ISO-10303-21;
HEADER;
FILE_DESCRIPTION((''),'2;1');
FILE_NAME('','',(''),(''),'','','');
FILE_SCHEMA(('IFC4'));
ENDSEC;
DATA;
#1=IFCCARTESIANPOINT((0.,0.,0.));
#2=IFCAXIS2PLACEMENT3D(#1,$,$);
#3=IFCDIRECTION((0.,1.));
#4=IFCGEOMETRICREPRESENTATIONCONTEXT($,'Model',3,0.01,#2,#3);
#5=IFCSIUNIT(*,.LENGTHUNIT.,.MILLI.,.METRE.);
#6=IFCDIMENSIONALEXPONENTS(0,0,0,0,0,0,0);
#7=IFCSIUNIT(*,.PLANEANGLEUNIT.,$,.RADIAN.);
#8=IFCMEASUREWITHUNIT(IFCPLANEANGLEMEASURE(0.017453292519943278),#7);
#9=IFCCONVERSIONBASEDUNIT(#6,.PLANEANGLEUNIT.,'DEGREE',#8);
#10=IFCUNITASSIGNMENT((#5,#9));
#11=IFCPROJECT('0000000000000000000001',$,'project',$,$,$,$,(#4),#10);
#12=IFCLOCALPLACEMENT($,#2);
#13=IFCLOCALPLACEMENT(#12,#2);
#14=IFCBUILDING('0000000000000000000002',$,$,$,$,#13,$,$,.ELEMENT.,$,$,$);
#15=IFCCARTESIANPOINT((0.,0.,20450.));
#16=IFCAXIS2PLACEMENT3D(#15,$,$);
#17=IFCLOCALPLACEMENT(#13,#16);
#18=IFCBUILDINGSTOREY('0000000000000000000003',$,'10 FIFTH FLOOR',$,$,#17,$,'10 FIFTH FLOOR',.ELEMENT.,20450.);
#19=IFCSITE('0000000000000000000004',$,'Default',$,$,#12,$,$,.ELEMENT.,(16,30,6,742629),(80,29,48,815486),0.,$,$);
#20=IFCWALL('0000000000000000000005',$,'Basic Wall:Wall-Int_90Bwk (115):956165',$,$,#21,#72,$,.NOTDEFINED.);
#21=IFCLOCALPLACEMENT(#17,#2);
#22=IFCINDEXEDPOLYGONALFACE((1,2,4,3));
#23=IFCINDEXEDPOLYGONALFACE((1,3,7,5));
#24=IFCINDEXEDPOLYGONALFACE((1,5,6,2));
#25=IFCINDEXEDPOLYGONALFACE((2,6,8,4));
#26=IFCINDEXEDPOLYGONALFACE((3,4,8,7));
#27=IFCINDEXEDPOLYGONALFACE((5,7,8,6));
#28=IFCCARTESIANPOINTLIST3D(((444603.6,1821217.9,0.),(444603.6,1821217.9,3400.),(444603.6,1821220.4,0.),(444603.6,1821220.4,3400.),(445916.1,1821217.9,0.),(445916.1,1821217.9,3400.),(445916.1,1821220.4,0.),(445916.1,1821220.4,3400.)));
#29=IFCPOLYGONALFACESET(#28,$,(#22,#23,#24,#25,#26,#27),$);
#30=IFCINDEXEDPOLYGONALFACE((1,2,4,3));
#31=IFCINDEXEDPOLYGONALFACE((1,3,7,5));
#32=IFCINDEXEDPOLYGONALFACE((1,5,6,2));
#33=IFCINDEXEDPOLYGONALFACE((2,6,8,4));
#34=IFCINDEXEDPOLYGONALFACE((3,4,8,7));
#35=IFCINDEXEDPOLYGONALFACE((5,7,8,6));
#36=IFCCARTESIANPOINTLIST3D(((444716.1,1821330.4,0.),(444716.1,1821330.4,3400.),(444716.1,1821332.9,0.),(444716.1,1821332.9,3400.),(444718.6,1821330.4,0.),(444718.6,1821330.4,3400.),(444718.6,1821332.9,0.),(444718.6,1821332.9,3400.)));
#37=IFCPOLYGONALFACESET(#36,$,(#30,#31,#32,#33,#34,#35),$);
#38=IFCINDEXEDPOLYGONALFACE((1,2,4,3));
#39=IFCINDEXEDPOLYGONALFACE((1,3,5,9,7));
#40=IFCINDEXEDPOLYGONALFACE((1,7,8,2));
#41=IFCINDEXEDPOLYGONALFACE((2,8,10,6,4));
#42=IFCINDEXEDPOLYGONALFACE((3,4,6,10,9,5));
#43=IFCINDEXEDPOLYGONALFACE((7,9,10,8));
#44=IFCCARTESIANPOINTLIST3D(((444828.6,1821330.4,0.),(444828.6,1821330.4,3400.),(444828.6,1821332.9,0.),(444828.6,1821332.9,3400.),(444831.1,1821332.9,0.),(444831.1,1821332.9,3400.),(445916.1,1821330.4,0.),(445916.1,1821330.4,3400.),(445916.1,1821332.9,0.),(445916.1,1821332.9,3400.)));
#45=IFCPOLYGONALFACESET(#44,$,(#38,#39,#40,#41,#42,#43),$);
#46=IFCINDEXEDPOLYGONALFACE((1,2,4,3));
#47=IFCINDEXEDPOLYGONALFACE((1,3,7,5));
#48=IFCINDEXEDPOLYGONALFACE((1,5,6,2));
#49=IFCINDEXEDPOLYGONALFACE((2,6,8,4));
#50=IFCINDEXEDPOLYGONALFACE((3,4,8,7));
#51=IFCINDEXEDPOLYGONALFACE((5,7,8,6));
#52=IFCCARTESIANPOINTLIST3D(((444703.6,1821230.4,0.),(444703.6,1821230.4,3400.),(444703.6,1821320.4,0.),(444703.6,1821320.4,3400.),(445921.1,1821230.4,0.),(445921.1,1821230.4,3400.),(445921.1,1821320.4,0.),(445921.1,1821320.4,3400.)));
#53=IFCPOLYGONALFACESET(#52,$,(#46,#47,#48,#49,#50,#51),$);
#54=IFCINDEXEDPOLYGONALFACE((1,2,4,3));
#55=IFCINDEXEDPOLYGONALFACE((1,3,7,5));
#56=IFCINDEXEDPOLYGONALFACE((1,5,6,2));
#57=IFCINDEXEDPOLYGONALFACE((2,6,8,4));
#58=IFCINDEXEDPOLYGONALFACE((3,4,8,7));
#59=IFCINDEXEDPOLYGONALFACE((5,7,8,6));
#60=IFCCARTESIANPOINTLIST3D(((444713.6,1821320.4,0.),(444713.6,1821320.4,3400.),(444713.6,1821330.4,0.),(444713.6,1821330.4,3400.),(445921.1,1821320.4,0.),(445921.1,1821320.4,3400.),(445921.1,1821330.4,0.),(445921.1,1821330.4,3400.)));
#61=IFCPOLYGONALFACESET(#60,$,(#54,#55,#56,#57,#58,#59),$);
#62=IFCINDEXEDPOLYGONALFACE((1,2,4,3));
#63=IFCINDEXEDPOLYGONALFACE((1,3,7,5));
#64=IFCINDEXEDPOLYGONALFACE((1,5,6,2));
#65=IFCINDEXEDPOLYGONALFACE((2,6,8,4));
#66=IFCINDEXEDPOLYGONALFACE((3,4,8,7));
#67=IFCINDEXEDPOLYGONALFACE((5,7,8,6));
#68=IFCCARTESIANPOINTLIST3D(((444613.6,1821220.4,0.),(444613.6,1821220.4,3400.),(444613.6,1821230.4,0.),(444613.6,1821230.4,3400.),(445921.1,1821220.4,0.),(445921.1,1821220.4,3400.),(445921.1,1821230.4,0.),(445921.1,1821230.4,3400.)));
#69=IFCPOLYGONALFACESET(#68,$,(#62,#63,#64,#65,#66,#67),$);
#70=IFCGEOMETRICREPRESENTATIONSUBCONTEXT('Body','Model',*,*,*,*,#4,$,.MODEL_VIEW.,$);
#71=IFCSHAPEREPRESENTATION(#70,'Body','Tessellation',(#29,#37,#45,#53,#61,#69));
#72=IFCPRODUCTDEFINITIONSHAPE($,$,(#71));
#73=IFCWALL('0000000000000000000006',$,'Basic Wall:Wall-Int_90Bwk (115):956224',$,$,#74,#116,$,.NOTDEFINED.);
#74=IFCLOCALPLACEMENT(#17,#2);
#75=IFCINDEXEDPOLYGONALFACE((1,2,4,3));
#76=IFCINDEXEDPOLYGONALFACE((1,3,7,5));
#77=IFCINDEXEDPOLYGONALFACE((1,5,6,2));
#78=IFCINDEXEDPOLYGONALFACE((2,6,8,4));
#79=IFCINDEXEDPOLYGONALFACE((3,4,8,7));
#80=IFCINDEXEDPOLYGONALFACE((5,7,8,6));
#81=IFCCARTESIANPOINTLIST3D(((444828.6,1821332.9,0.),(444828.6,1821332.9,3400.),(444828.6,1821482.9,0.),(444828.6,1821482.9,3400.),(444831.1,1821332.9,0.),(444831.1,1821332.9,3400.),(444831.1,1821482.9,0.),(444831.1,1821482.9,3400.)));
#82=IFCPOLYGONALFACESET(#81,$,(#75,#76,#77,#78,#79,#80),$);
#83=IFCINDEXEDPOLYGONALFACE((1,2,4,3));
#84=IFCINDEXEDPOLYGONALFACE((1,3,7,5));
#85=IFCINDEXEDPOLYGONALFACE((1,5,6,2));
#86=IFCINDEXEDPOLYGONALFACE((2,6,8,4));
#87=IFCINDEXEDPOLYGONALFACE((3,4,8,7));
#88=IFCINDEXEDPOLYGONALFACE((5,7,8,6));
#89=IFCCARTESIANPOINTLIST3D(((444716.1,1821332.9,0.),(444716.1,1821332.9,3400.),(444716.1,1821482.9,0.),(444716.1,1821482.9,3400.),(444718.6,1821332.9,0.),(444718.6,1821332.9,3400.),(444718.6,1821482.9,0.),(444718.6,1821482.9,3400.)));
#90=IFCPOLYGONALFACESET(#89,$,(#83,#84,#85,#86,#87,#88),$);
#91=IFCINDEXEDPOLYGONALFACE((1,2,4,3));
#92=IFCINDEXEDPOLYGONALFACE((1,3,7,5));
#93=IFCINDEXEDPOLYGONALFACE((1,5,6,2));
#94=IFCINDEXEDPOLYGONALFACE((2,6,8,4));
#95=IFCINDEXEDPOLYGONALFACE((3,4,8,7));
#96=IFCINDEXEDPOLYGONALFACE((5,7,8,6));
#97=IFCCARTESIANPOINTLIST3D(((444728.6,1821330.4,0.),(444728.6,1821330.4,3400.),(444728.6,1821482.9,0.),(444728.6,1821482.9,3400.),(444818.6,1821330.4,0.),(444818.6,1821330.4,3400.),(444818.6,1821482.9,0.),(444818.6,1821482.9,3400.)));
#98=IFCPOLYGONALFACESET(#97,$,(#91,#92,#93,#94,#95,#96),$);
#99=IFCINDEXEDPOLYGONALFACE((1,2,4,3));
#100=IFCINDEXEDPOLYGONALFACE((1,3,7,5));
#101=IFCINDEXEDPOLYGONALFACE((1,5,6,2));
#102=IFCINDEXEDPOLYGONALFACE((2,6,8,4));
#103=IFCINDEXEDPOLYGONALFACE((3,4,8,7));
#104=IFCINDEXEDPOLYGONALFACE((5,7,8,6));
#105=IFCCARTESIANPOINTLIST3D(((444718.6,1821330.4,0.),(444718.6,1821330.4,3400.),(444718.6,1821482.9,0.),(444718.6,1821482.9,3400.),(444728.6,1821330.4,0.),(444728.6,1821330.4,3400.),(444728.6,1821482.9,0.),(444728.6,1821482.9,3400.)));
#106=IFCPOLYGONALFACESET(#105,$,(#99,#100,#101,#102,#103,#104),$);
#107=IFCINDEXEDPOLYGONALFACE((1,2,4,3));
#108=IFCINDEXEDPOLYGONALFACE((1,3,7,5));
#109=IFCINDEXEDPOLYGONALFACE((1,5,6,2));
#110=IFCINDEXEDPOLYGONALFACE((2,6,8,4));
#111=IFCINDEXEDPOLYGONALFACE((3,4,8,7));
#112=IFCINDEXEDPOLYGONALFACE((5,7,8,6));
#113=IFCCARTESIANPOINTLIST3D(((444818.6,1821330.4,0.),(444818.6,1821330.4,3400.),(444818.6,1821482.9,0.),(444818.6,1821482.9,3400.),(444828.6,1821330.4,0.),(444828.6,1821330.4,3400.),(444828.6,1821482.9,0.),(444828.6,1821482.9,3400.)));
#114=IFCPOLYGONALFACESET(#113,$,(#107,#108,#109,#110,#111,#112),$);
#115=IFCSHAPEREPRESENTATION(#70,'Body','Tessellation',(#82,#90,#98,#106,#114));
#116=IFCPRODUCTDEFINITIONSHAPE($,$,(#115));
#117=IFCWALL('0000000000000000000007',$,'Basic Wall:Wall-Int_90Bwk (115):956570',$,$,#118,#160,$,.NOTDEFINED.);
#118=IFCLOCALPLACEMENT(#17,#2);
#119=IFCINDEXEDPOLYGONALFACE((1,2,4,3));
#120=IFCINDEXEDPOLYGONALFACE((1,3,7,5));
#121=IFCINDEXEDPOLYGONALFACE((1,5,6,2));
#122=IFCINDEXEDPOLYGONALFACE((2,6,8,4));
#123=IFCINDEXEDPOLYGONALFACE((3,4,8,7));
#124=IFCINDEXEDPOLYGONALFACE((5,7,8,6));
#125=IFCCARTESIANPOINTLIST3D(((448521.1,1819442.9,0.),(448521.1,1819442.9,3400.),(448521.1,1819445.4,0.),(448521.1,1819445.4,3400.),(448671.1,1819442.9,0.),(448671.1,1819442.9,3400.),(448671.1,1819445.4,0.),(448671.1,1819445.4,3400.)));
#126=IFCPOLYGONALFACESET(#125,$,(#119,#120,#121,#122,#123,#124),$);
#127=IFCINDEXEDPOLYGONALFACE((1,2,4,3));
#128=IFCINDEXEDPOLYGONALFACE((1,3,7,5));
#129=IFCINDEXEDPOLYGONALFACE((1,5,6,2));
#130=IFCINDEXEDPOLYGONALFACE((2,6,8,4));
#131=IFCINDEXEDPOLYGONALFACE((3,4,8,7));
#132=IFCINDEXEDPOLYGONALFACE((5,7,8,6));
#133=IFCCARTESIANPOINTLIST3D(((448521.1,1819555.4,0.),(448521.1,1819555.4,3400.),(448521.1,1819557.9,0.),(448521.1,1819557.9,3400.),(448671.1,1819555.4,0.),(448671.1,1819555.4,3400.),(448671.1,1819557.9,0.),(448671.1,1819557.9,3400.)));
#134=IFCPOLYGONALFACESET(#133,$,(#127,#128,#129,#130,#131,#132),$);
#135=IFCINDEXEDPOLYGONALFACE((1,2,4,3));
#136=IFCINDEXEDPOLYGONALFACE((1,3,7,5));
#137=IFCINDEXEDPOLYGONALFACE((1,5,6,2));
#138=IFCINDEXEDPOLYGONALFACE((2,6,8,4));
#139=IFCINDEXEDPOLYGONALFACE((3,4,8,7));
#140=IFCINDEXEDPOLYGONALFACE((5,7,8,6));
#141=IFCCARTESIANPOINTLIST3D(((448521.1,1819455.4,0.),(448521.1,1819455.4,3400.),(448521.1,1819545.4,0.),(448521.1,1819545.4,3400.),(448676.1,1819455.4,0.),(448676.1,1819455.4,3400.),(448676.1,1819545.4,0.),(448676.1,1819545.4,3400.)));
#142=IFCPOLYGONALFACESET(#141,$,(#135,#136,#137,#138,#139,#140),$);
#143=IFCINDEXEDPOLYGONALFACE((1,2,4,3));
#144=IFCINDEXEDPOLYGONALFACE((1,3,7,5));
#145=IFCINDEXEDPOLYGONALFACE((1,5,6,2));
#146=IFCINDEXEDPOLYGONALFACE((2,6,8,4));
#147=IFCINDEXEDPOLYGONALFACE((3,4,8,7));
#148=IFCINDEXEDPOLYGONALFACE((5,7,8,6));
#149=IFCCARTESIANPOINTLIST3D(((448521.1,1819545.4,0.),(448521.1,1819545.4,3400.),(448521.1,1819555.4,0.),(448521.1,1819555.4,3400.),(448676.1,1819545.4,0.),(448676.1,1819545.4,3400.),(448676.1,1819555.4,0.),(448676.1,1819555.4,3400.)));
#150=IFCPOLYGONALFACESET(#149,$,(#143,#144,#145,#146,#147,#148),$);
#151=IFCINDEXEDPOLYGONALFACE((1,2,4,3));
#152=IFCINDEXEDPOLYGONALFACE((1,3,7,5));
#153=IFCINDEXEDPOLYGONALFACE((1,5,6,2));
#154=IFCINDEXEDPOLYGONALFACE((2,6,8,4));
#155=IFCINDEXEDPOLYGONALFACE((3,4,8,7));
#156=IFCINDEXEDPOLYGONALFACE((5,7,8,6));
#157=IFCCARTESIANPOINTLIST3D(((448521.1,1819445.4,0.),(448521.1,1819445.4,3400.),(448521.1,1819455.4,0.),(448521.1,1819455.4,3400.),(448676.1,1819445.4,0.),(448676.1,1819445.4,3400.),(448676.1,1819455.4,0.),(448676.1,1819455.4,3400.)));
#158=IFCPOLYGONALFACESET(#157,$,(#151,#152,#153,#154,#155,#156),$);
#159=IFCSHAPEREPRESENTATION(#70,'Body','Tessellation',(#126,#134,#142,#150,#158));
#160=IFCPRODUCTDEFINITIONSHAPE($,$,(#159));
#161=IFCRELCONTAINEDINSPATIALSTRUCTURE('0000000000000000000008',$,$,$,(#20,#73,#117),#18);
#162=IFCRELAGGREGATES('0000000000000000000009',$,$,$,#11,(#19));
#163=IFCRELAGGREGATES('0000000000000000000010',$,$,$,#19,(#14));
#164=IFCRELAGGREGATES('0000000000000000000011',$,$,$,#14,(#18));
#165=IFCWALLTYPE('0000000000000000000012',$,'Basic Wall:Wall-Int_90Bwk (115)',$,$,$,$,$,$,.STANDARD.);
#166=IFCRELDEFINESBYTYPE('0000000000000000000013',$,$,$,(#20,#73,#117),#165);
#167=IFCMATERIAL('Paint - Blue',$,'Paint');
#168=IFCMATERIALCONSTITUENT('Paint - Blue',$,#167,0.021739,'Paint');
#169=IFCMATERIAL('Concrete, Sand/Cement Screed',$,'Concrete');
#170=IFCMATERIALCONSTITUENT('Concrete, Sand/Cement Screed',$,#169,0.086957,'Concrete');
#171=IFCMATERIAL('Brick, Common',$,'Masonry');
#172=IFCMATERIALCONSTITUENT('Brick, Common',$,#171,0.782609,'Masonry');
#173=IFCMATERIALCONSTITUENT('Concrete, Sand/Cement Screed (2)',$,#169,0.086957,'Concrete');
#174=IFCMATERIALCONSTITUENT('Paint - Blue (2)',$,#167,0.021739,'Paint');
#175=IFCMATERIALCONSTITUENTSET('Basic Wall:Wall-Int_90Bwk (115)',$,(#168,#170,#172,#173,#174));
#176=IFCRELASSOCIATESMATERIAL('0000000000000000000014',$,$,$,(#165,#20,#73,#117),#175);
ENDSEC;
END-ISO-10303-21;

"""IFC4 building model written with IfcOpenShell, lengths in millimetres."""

from ifc_helpers import new_model, entity, si_unit, converted_unit, direction, frame, origin, place, context, subcontext, project, spatial, indexed_curve, outline, extrude, material, constituent, constituent_set, type_object, element, save


model = new_model("IFC4")

# Units and contexts
model_context = context("Model", 3, precision=0.01, world=origin(), true_north=direction((0.0, 1.0)))
body_context = subcontext(model_context, "Body", "Model", "MODEL_VIEW")
ifc_project = project(units=[si_unit("LENGTHUNIT", "METRE", prefix="MILLI"), converted_unit("PLANEANGLEUNIT", "DEGREE", entity("IfcPlaneAngleMeasure", 0.017453292519943278), si_unit("PLANEANGLEUNIT", "RADIAN"), dimensions=[0, 0, 0, 0, 0, 0, 0])], contexts=[model_context])

# Site, building, storey
site_placement = place(None, origin())
site = spatial("IfcSite", under=ifc_project, at=site_placement, Name="Default", CompositionType="ELEMENT", RefLatitude=(16, 30, 6, 742629), RefLongitude=(80, 29, 48, 815486), RefElevation=0.0)
building_placement = place(site_placement, origin())
building = spatial("IfcBuilding", under=site, at=building_placement, CompositionType="ELEMENT")
storey_placement = place(building_placement, frame((0.0, 0.0, 20450.0)))
storey = spatial("IfcBuildingStorey", under=building, at=storey_placement, Name="10 FIFTH FLOOR", LongName="10 FIFTH FLOOR", CompositionType="ELEMENT", Elevation=20450.0)

# Shared definitions
ifc_material_1 = material(Name="Paint - Blue", Category="Paint")
ifc_constituent_1 = constituent(ifc_material_1, Name="Paint - Blue", Category="Paint", fraction=0.021739)
ifc_material_2 = material(Name="Concrete, Sand/Cement Screed", Category="Concrete")
ifc_constituent_2 = constituent(ifc_material_2, Name="Concrete, Sand/Cement Screed", Category="Concrete", fraction=0.086957)
ifc_material_3 = material(Name="Brick, Common", Category="Masonry")
ifc_constituent_3 = constituent(ifc_material_3, Name="Brick, Common", Category="Masonry", fraction=0.782609)
ifc_constituent_4 = constituent(ifc_material_2, Name="Concrete, Sand/Cement Screed (2)", Category="Concrete", fraction=0.086957)
ifc_constituent_5 = constituent(ifc_material_1, Name="Paint - Blue (2)", Category="Paint", fraction=0.021739)
ifc_constituent_set_1 = constituent_set(constituents=[ifc_constituent_1, ifc_constituent_2, ifc_constituent_3, ifc_constituent_4, ifc_constituent_5], Name="Basic Wall:Wall-Int_90Bwk (115)")
wall_type_1 = type_object("IfcWallType", Name="Basic Wall:Wall-Int_90Bwk (115)", PredefinedType="STANDARD", material=ifc_constituent_set_1)

# Walls
wall_1_placement = place(storey_placement, frame((445916.1, 1821275.4, 0.0), z_axis=(0.0, 0.0, 1.0), x_axis=(-1.0, 0.0, 0.0)))
element("IfcWall", 1, at=wall_1_placement, inside=storey, type_object=wall_type_1, material=ifc_constituent_set_1, Name="Basic Wall:Wall-Int_90Bwk (115):956165", PredefinedType="NOTDEFINED", context=body_context, shape_type="SweptSolid", body=[
    extrude(outline(indexed_curve([(-1.3, -656.2), (1.3, -656.2), (1.3, 656.2), (-1.3, 656.2), (-1.3, -656.2)], self_intersect=False)), frame((656.2, 56.3, 0.0), z_axis=(0.0, 0.0, 1.0), x_axis=(0.0, -1.0, 0.0)), (0.0, 0.0, 1.0), 3400.0),
    extrude(outline(indexed_curve([(-1.3, -1.3), (1.3, -1.3), (1.3, 1.2), (-1.3, 1.2), (-1.3, -1.3)], self_intersect=False)), frame((1198.7, -56.3, 0.0), z_axis=(0.0, 0.0, 1.0), x_axis=(-1.0, 0.0, 0.0)), (0.0, 0.0, 1.0), 3400.0),
    extrude(outline(indexed_curve([(433.0, -1.0), (435.5, -1.0), (435.5, 1.5), (-652.0, 1.5), (-652.0, -1.0), (433.0, -1.0)], self_intersect=False)), frame((652.0, -56.5, 0.0)), (0.0, 0.0, 1.0), 3400.0),
    extrude(outline(indexed_curve([(-608.7, -45.0), (608.7, -45.0), (608.7, 45.0), (-608.7, 45.0), (-608.7, -45.0)], self_intersect=False)), frame((603.7, 0.0, 0.0)), (0.0, 0.0, 1.0), 3400.0),
    extrude(outline(indexed_curve([(-603.7, -5.0), (603.7, -5.0), (603.7, 5.0), (-603.7, 5.0), (-603.7, -5.0)], self_intersect=False)), frame((598.7, -50.0, 0.0)), (0.0, 0.0, 1.0), 3400.0),
    extrude(outline(indexed_curve([(-653.7, -5.0), (653.7, -5.0), (653.7, 5.0), (-653.7, 5.0), (-653.7, -5.0)], self_intersect=False)), frame((648.7, 50.0, 0.0)), (0.0, 0.0, 1.0), 3400.0),
])
wall_2_placement = place(storey_placement, frame((444773.6, 1821332.9, 0.0), z_axis=(0.0, 0.0, 1.0), x_axis=(0.0, 1.0, 0.0)))
element("IfcWall", 2, at=wall_2_placement, inside=storey, type_object=wall_type_1, material=ifc_constituent_set_1, Name="Basic Wall:Wall-Int_90Bwk (115):956224", PredefinedType="NOTDEFINED", context=body_context, shape_type="SweptSolid", body=[
    extrude(outline(indexed_curve([(-1.3, -75.0), (1.2, -75.0), (1.2, 75.0), (-1.3, 75.0), (-1.3, -75.0)], self_intersect=False)), frame((75.0, -56.2, 0.0), z_axis=(0.0, 0.0, 1.0), x_axis=(0.0, 1.0, 0.0)), (0.0, 0.0, 1.0), 3400.0),
    extrude(outline(indexed_curve([(-1.3, -75.0), (1.2, -75.0), (1.2, 75.0), (-1.3, 75.0), (-1.3, -75.0)], self_intersect=False)), frame((75.0, 56.2, 0.0), z_axis=(0.0, 0.0, 1.0), x_axis=(0.0, -1.0, 0.0)), (0.0, 0.0, 1.0), 3400.0),
    extrude(outline(indexed_curve([(-76.3, -45.0), (76.3, -45.0), (76.3, 45.0), (-76.3, 45.0), (-76.3, -45.0)], self_intersect=False)), frame((73.8, 0.0, 0.0)), (0.0, 0.0, 1.0), 3400.0),
    extrude(outline(indexed_curve([(-76.3, -5.0), (76.3, -5.0), (76.3, 5.0), (-76.3, 5.0), (-76.3, -5.0)], self_intersect=False)), frame((73.8, 50.0, 0.0)), (0.0, 0.0, 1.0), 3400.0),
    extrude(outline(indexed_curve([(-76.3, -5.0), (76.3, -5.0), (76.3, 5.0), (-76.3, 5.0), (-76.3, -5.0)], self_intersect=False)), frame((73.8, -50.0, 0.0)), (0.0, 0.0, 1.0), 3400.0),
])
wall_3_placement = place(storey_placement, frame((448671.1, 1819500.4, 0.0), z_axis=(0.0, 0.0, 1.0), x_axis=(-1.0, 0.0, 0.0)))
element("IfcWall", 3, at=wall_3_placement, inside=storey, type_object=wall_type_1, material=ifc_constituent_set_1, Name="Basic Wall:Wall-Int_90Bwk (115):956570", PredefinedType="NOTDEFINED", context=body_context, shape_type="SweptSolid", body=[
    extrude(outline(indexed_curve([(-1.3, -75.0), (1.3, -75.0), (1.3, 75.0), (-1.3, 75.0), (-1.3, -75.0)], self_intersect=False)), frame((75.0, 56.3, 0.0), z_axis=(0.0, 0.0, 1.0), x_axis=(0.0, -1.0, 0.0)), (0.0, 0.0, 1.0), 3400.0),
    extrude(outline(indexed_curve([(-1.3, -75.0), (1.2, -75.0), (1.2, 75.0), (-1.3, 75.0), (-1.3, -75.0)], self_intersect=False)), frame((75.0, -56.2, 0.0), z_axis=(0.0, 0.0, 1.0), x_axis=(0.0, 1.0, 0.0)), (0.0, 0.0, 1.0), 3400.0),
    extrude(outline(indexed_curve([(-77.5, -45.0), (77.5, -45.0), (77.5, 45.0), (-77.5, 45.0), (-77.5, -45.0)], self_intersect=False)), frame((72.5, 0.0, 0.0)), (0.0, 0.0, 1.0), 3400.0),
    extrude(outline(indexed_curve([(-77.5, -5.0), (77.5, -5.0), (77.5, 5.0), (-77.5, 5.0), (-77.5, -5.0)], self_intersect=False)), frame((72.5, -50.0, 0.0)), (0.0, 0.0, 1.0), 3400.0),
    extrude(outline(indexed_curve([(-77.5, -5.0), (77.5, -5.0), (77.5, 5.0), (-77.5, 5.0), (-77.5, -5.0)], self_intersect=False)), frame((72.5, 50.0, 0.0)), (0.0, 0.0, 1.0), 3400.0),
])

save(model, "model.ifc")
